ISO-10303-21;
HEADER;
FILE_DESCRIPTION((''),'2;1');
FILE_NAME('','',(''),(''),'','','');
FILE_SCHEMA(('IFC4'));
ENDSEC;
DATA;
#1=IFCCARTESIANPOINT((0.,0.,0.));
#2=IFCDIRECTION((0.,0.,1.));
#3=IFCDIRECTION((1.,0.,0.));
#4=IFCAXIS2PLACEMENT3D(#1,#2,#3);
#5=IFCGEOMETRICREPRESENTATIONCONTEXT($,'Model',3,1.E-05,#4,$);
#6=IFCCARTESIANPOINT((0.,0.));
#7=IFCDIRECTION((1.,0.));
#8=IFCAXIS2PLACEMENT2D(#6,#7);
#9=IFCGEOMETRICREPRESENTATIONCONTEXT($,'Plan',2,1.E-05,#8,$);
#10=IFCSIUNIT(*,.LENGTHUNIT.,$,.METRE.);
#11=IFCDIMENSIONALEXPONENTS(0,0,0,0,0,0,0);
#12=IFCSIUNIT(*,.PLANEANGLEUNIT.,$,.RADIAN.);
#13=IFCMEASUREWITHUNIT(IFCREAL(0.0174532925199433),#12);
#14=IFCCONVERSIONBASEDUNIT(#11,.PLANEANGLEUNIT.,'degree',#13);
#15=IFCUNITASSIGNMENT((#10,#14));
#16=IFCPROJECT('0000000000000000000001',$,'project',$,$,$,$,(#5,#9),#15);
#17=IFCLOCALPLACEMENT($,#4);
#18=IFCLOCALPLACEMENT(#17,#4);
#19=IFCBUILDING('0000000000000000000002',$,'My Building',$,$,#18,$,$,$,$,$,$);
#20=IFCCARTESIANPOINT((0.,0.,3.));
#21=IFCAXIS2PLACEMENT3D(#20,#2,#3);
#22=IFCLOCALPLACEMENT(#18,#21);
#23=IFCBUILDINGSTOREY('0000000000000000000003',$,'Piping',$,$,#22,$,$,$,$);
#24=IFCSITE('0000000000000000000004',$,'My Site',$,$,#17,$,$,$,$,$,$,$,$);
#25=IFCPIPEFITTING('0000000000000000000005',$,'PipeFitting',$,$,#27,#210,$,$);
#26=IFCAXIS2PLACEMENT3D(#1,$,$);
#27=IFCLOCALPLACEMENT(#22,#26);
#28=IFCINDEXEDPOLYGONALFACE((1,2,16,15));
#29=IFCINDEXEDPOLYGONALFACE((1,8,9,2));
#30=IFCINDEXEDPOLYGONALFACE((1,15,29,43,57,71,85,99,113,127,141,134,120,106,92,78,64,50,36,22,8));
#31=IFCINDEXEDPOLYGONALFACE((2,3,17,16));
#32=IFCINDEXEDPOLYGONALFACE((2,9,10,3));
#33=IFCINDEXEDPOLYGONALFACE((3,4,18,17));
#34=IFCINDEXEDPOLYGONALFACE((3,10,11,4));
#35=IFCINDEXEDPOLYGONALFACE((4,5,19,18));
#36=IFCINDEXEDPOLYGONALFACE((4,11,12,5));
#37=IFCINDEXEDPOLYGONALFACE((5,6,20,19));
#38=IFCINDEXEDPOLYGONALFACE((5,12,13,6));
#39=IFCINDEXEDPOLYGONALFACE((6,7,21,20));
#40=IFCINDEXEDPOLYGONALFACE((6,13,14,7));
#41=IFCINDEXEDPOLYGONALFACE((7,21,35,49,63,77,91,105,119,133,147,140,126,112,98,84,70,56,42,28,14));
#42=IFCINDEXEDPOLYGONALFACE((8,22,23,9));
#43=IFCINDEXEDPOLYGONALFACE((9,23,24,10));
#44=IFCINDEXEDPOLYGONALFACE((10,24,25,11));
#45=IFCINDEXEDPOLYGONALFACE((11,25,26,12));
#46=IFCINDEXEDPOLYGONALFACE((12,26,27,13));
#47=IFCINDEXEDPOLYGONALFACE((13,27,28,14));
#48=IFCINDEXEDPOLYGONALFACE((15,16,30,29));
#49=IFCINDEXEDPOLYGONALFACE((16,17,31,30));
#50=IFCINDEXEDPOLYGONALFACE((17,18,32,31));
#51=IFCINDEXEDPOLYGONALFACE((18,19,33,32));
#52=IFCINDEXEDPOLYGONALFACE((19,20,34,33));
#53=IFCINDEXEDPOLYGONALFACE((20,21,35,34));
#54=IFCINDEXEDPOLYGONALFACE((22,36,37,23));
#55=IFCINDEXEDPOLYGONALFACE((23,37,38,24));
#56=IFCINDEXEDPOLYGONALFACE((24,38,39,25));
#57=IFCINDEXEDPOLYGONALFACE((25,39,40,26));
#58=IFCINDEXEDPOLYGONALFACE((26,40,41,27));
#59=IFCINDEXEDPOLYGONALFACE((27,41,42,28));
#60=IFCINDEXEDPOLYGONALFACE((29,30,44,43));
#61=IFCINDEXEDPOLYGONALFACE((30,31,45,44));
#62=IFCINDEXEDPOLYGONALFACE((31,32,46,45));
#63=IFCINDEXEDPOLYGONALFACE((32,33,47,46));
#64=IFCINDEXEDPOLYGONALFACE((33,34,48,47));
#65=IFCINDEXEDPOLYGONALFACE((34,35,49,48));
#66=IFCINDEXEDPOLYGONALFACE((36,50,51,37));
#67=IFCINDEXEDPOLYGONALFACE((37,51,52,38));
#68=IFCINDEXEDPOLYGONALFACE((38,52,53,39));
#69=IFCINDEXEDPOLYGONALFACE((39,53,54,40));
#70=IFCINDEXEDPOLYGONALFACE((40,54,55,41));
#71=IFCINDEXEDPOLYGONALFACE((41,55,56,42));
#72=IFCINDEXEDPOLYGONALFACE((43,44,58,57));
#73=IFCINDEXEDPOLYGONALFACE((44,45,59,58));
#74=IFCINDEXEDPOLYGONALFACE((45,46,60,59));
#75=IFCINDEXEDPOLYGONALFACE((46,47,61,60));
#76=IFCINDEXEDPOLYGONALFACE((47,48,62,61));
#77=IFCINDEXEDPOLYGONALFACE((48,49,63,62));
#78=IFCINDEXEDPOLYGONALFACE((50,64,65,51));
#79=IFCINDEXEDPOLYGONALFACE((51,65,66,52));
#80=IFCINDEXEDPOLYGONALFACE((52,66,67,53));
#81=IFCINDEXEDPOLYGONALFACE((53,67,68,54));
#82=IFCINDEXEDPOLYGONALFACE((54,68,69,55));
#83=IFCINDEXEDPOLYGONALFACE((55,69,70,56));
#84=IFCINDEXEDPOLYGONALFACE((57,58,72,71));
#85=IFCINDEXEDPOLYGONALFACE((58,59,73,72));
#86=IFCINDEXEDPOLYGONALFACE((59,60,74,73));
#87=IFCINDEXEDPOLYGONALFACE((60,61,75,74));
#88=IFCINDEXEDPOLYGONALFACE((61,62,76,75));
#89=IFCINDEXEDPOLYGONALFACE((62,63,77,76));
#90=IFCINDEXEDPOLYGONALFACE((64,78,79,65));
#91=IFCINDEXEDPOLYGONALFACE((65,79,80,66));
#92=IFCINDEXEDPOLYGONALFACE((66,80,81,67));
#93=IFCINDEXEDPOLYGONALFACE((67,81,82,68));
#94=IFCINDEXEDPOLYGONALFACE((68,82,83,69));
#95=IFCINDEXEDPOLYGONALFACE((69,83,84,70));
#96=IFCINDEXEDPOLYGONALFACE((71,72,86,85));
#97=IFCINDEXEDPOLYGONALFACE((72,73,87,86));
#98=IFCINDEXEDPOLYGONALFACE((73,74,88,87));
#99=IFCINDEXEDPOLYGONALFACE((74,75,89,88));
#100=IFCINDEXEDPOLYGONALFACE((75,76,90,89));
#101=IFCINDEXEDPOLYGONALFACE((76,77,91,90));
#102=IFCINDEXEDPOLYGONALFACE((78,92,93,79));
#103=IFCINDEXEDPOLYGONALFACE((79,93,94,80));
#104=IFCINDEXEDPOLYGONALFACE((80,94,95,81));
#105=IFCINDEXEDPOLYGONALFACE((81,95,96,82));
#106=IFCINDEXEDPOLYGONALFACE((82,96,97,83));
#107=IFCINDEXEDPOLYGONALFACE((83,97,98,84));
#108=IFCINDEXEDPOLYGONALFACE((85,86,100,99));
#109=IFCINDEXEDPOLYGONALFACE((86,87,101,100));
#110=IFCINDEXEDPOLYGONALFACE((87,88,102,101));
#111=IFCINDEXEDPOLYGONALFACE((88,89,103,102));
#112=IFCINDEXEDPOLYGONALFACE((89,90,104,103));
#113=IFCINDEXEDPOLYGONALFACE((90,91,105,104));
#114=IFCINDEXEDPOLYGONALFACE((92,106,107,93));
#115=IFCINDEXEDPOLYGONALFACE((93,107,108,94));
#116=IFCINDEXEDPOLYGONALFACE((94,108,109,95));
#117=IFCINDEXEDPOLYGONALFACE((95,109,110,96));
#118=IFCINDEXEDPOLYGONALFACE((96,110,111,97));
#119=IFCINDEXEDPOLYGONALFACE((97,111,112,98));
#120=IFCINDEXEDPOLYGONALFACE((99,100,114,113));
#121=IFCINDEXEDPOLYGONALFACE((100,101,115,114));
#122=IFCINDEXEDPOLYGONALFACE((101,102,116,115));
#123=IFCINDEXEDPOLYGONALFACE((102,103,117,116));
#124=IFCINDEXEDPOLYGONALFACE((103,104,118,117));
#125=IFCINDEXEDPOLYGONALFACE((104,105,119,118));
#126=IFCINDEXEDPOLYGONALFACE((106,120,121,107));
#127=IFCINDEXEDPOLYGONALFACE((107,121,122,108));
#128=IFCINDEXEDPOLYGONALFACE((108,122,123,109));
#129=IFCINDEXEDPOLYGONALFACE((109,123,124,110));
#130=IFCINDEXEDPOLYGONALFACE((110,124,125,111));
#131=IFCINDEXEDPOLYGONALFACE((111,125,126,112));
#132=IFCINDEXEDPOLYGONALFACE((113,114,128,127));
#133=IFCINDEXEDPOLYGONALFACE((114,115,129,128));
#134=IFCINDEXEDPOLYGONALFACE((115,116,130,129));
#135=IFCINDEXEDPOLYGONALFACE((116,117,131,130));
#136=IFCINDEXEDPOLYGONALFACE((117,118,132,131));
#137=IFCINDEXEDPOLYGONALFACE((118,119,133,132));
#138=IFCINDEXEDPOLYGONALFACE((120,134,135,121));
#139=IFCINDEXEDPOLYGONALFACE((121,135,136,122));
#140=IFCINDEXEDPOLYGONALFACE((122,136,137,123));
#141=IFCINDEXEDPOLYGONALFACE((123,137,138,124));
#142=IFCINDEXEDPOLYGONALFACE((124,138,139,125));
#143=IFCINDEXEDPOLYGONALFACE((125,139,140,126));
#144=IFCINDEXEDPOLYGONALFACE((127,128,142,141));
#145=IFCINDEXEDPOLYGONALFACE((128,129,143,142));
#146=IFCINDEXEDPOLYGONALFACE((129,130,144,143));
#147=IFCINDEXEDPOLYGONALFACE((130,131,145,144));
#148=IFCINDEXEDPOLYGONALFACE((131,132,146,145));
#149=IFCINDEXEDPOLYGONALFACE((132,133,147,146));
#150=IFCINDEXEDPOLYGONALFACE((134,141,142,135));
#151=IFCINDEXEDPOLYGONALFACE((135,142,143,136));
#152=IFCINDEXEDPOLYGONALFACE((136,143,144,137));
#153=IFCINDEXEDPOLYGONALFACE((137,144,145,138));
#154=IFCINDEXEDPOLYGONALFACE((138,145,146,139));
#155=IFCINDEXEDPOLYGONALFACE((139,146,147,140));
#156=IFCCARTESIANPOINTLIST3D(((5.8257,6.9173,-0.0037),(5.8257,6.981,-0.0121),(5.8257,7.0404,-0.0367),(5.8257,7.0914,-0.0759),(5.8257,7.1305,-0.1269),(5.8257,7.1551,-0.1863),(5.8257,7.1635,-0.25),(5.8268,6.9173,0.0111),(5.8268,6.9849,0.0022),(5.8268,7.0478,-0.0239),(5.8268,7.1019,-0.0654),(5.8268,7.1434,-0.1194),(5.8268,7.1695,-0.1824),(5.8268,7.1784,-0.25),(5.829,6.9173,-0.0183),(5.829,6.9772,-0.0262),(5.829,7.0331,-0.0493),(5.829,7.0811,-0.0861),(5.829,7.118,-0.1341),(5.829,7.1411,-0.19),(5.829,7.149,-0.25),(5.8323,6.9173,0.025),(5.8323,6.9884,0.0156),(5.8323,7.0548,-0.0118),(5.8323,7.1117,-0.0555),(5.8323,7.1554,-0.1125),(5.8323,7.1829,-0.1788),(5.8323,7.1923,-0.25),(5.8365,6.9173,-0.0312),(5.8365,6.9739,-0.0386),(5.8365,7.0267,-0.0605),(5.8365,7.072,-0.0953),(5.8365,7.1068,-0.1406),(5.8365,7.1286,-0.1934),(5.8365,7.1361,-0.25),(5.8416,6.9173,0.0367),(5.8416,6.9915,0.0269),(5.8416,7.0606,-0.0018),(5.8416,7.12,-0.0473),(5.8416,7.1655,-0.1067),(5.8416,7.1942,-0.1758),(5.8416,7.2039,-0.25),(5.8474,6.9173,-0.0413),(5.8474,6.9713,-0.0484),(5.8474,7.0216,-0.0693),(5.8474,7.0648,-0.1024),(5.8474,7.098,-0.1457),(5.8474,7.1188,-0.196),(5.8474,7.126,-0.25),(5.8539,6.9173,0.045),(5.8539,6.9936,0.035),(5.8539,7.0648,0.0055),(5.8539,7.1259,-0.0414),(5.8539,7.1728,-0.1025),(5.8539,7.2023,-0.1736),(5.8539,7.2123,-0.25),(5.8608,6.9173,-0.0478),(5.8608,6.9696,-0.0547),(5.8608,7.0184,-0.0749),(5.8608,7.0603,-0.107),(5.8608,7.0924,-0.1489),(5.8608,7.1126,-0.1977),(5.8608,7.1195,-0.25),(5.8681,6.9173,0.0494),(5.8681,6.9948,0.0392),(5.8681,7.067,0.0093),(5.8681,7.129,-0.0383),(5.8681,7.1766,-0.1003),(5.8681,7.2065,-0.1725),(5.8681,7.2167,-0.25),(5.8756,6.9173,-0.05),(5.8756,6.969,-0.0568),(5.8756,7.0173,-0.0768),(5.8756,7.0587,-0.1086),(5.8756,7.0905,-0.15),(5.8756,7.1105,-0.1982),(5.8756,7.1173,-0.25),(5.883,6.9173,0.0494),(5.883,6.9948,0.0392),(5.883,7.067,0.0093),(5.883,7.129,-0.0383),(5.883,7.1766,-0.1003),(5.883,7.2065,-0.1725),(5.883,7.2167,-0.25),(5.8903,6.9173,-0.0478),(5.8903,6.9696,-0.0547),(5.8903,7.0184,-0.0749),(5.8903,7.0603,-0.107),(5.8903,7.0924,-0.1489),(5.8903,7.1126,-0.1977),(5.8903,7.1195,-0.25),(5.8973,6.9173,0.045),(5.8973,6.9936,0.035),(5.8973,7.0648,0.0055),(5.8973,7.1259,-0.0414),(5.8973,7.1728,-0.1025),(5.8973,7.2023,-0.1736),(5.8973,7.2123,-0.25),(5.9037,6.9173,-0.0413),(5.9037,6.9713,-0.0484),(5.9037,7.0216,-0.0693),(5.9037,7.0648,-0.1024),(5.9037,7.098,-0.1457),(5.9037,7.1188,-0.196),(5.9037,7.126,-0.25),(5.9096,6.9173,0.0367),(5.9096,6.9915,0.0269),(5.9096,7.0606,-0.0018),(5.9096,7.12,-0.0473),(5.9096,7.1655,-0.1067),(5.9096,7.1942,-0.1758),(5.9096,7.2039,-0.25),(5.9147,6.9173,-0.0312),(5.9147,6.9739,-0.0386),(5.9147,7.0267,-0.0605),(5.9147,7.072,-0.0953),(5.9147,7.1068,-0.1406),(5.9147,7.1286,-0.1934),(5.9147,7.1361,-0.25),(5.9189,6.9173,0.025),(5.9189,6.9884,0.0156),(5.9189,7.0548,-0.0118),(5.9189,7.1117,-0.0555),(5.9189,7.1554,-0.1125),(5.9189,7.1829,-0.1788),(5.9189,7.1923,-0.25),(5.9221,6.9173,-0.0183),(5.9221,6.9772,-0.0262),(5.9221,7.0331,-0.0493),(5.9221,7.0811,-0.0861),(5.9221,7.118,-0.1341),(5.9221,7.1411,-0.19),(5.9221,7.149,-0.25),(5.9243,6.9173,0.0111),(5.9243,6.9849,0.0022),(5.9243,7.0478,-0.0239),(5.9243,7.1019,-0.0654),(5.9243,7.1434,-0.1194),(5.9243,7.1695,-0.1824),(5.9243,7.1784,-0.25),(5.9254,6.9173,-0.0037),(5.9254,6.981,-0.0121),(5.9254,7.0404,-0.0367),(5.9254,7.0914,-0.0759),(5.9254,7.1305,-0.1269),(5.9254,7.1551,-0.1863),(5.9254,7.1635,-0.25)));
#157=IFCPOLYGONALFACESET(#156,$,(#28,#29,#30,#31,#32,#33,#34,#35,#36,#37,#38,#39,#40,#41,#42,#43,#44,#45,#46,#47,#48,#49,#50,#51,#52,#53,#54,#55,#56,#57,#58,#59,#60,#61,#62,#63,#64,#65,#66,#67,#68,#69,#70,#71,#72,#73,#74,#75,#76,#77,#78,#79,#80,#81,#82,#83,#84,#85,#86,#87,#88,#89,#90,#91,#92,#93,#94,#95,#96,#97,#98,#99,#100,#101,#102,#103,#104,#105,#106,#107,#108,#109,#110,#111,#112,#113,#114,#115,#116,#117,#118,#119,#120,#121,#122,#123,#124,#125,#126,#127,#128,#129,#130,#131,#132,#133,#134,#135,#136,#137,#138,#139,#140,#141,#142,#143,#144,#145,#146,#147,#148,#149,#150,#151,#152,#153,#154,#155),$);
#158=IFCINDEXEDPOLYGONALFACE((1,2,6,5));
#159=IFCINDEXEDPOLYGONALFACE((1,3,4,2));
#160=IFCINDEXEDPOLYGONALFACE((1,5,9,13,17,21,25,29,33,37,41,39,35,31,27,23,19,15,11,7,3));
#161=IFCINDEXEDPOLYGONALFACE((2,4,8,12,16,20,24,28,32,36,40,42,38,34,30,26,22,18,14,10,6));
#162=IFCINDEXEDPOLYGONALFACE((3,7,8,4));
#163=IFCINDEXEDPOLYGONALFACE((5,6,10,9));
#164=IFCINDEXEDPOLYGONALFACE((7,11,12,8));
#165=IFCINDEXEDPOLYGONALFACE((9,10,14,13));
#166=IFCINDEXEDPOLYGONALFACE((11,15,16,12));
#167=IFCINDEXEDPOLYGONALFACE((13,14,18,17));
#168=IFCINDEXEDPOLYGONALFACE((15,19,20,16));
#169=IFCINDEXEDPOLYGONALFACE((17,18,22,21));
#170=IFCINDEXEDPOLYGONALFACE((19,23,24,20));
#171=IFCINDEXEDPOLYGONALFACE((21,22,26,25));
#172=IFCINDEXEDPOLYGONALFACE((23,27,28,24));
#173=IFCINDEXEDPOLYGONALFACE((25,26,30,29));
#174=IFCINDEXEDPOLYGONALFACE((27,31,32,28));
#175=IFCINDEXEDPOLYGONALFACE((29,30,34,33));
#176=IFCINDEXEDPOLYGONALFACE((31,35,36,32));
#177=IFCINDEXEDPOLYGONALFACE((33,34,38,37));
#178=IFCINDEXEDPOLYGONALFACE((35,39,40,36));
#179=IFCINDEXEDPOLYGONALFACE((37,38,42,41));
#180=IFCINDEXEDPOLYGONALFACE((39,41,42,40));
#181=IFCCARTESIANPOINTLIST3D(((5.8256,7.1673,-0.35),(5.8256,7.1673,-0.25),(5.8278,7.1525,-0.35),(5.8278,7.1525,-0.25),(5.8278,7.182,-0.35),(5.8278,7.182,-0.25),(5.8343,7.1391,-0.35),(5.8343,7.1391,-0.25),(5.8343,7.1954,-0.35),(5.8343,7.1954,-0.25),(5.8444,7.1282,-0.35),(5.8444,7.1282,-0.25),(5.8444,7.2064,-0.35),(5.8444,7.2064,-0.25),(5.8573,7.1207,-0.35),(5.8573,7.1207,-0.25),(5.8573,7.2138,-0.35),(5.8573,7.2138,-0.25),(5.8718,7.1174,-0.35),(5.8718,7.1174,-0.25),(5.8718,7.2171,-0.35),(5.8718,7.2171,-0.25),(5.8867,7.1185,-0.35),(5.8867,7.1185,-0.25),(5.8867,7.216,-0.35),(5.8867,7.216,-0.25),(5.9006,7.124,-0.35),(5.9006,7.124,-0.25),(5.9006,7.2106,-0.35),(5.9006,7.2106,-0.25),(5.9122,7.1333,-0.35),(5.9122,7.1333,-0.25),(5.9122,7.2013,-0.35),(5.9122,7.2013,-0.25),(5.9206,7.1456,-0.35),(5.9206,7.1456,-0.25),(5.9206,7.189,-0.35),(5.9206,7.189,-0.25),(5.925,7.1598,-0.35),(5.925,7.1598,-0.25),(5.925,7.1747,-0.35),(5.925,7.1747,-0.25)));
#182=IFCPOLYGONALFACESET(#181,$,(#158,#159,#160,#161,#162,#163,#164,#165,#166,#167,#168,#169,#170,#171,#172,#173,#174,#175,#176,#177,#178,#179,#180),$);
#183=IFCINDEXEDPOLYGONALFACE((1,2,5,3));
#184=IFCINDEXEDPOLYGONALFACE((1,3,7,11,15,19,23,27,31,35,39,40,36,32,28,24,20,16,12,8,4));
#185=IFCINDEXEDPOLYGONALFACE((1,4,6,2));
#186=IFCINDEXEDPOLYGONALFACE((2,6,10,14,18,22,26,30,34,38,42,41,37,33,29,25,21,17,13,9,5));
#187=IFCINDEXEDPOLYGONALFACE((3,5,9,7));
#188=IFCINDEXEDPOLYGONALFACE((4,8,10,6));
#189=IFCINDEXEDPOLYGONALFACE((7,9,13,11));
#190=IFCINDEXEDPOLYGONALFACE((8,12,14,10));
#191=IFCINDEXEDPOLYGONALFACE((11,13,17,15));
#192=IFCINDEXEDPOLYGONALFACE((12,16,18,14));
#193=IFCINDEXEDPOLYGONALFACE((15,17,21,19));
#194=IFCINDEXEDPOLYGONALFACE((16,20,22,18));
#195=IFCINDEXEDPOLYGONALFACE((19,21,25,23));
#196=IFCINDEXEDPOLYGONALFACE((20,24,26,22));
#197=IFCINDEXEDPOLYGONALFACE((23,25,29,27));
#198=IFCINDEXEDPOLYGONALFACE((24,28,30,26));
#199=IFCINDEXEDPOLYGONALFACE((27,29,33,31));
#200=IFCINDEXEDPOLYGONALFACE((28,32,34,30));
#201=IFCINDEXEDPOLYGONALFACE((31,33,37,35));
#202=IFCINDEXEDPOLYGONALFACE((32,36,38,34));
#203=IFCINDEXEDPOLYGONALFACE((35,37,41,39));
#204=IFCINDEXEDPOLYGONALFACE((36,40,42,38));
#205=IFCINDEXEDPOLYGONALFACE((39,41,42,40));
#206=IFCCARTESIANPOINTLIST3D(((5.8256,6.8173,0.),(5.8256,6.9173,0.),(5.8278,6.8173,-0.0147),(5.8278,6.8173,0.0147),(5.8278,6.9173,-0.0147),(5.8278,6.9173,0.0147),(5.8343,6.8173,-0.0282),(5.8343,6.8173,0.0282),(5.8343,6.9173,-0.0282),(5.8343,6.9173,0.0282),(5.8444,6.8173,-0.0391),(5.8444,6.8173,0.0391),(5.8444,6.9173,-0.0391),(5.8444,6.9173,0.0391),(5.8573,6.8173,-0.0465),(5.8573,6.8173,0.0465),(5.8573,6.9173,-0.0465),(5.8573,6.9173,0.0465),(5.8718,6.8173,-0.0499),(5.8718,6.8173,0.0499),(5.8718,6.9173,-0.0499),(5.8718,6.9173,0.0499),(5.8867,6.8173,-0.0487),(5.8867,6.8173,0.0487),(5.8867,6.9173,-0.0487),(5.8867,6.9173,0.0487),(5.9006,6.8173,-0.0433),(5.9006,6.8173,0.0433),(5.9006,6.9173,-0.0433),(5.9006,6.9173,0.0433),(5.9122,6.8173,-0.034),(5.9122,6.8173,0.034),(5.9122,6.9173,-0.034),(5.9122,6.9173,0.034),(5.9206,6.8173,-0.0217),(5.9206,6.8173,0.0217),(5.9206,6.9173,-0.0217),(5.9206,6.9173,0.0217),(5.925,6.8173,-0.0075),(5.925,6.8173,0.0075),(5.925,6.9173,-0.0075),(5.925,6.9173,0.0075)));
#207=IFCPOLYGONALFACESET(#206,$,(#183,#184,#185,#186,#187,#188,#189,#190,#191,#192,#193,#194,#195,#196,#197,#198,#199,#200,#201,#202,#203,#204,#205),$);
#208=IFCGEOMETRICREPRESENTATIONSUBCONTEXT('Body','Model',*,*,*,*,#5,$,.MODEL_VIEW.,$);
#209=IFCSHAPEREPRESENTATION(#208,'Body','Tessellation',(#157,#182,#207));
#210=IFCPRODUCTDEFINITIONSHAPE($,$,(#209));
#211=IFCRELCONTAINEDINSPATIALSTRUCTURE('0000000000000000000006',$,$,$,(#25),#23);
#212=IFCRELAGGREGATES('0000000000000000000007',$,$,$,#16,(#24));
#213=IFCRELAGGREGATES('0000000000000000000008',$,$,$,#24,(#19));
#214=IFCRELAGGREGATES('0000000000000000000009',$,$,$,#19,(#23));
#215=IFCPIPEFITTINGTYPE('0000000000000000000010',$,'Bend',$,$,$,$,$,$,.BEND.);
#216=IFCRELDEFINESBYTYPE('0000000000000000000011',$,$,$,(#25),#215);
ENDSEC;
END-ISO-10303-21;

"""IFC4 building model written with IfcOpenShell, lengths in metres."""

from ifc_helpers import new_model, entity, si_unit, converted_unit, frame, origin_with_axes, origin_2d_with_axis, place, context, subcontext, project, spatial, circle, extrude, source, transform, mapped, type_object, type_shapes, element, save


model = new_model("IFC4")

# Units and contexts
model_context = context("Model", 3, precision=1e-05, world=origin_with_axes())
plan_context = context("Plan", 2, precision=1e-05, world=origin_2d_with_axis())
body_context = subcontext(model_context, "Body", "Model", "MODEL_VIEW")
ifc_project = project(units=[si_unit("LENGTHUNIT", "METRE"), converted_unit("PLANEANGLEUNIT", "degree", entity("IfcReal", 0.0174532925199433), si_unit("PLANEANGLEUNIT", "RADIAN"), dimensions=[0, 0, 0, 0, 0, 0, 0])], contexts=[model_context, plan_context])

# Site, building, storey
site_placement = place(None, origin_with_axes())
site = spatial("IfcSite", under=ifc_project, at=site_placement, Name="My Site")
building_placement = place(site_placement, origin_with_axes())
building = spatial("IfcBuilding", under=site, at=building_placement, Name="My Building")
storey_placement = place(building_placement, frame((0.0, 0.0, 3.0), z_axis=(0.0, 0.0, 1.0), x_axis=(1.0, 0.0, 0.0)))
storey = spatial("IfcBuildingStorey", under=building, at=storey_placement, Name="Piping")

# Pipe fitting
pipe_fitting_type = type_object("IfcPipeFittingType", Name="Bend", PredefinedType="BEND")
shared_shape = source(origin_with_axes(), body_context, "Body", "SolidModel", [
    entity("IfcSweptDiskSolid", entity("IfcIndexedPolyCurve", entity("IfcCartesianPointList3D", [[0.0, 0.0, -0.1], [0.0, -0.0732, -0.2768], [0.0, -0.25, -0.35]]), [entity("IfcArcIndex", [1, 2, 3])]), 0.05),
    extrude(circle(Radius=0.05), origin_with_axes(), (0.0, 0.0, -1.0), 0.1),
    extrude(circle(Radius=0.05), frame((0.0, -0.25, -0.35), z_axis=(0.0, -1.0, 0.0), x_axis=(1.0, 0.0, 0.0)), (0.0, 0.0, 1.0), 0.1),
])
type_shapes(pipe_fitting_type, [shared_shape])
for number, where, z_axis, x_axis, name in (
    (1, (5.8756, 7.1673, -0.35), (0.0, 0.0, -1.0), (-1.0, 0.0, 0.0), "PipeFitting"),
):
    element("IfcPipeFitting", number, at=place(storey_placement, frame(where, z_axis=z_axis, x_axis=x_axis)), inside=storey, type_object=pipe_fitting_type, Name=name, context=body_context, shape_type="MappedRepresentation", body=[
        mapped(shared_shape, transform((0.0, 0.0, 0.0), x_axis=(1.0, 0.0, 0.0), y_axis=(0.0, 1.0, 0.0), z_axis=(0.0, 0.0, 1.0), scale=1.0)),
    ])

save(model, "model.ifc")
